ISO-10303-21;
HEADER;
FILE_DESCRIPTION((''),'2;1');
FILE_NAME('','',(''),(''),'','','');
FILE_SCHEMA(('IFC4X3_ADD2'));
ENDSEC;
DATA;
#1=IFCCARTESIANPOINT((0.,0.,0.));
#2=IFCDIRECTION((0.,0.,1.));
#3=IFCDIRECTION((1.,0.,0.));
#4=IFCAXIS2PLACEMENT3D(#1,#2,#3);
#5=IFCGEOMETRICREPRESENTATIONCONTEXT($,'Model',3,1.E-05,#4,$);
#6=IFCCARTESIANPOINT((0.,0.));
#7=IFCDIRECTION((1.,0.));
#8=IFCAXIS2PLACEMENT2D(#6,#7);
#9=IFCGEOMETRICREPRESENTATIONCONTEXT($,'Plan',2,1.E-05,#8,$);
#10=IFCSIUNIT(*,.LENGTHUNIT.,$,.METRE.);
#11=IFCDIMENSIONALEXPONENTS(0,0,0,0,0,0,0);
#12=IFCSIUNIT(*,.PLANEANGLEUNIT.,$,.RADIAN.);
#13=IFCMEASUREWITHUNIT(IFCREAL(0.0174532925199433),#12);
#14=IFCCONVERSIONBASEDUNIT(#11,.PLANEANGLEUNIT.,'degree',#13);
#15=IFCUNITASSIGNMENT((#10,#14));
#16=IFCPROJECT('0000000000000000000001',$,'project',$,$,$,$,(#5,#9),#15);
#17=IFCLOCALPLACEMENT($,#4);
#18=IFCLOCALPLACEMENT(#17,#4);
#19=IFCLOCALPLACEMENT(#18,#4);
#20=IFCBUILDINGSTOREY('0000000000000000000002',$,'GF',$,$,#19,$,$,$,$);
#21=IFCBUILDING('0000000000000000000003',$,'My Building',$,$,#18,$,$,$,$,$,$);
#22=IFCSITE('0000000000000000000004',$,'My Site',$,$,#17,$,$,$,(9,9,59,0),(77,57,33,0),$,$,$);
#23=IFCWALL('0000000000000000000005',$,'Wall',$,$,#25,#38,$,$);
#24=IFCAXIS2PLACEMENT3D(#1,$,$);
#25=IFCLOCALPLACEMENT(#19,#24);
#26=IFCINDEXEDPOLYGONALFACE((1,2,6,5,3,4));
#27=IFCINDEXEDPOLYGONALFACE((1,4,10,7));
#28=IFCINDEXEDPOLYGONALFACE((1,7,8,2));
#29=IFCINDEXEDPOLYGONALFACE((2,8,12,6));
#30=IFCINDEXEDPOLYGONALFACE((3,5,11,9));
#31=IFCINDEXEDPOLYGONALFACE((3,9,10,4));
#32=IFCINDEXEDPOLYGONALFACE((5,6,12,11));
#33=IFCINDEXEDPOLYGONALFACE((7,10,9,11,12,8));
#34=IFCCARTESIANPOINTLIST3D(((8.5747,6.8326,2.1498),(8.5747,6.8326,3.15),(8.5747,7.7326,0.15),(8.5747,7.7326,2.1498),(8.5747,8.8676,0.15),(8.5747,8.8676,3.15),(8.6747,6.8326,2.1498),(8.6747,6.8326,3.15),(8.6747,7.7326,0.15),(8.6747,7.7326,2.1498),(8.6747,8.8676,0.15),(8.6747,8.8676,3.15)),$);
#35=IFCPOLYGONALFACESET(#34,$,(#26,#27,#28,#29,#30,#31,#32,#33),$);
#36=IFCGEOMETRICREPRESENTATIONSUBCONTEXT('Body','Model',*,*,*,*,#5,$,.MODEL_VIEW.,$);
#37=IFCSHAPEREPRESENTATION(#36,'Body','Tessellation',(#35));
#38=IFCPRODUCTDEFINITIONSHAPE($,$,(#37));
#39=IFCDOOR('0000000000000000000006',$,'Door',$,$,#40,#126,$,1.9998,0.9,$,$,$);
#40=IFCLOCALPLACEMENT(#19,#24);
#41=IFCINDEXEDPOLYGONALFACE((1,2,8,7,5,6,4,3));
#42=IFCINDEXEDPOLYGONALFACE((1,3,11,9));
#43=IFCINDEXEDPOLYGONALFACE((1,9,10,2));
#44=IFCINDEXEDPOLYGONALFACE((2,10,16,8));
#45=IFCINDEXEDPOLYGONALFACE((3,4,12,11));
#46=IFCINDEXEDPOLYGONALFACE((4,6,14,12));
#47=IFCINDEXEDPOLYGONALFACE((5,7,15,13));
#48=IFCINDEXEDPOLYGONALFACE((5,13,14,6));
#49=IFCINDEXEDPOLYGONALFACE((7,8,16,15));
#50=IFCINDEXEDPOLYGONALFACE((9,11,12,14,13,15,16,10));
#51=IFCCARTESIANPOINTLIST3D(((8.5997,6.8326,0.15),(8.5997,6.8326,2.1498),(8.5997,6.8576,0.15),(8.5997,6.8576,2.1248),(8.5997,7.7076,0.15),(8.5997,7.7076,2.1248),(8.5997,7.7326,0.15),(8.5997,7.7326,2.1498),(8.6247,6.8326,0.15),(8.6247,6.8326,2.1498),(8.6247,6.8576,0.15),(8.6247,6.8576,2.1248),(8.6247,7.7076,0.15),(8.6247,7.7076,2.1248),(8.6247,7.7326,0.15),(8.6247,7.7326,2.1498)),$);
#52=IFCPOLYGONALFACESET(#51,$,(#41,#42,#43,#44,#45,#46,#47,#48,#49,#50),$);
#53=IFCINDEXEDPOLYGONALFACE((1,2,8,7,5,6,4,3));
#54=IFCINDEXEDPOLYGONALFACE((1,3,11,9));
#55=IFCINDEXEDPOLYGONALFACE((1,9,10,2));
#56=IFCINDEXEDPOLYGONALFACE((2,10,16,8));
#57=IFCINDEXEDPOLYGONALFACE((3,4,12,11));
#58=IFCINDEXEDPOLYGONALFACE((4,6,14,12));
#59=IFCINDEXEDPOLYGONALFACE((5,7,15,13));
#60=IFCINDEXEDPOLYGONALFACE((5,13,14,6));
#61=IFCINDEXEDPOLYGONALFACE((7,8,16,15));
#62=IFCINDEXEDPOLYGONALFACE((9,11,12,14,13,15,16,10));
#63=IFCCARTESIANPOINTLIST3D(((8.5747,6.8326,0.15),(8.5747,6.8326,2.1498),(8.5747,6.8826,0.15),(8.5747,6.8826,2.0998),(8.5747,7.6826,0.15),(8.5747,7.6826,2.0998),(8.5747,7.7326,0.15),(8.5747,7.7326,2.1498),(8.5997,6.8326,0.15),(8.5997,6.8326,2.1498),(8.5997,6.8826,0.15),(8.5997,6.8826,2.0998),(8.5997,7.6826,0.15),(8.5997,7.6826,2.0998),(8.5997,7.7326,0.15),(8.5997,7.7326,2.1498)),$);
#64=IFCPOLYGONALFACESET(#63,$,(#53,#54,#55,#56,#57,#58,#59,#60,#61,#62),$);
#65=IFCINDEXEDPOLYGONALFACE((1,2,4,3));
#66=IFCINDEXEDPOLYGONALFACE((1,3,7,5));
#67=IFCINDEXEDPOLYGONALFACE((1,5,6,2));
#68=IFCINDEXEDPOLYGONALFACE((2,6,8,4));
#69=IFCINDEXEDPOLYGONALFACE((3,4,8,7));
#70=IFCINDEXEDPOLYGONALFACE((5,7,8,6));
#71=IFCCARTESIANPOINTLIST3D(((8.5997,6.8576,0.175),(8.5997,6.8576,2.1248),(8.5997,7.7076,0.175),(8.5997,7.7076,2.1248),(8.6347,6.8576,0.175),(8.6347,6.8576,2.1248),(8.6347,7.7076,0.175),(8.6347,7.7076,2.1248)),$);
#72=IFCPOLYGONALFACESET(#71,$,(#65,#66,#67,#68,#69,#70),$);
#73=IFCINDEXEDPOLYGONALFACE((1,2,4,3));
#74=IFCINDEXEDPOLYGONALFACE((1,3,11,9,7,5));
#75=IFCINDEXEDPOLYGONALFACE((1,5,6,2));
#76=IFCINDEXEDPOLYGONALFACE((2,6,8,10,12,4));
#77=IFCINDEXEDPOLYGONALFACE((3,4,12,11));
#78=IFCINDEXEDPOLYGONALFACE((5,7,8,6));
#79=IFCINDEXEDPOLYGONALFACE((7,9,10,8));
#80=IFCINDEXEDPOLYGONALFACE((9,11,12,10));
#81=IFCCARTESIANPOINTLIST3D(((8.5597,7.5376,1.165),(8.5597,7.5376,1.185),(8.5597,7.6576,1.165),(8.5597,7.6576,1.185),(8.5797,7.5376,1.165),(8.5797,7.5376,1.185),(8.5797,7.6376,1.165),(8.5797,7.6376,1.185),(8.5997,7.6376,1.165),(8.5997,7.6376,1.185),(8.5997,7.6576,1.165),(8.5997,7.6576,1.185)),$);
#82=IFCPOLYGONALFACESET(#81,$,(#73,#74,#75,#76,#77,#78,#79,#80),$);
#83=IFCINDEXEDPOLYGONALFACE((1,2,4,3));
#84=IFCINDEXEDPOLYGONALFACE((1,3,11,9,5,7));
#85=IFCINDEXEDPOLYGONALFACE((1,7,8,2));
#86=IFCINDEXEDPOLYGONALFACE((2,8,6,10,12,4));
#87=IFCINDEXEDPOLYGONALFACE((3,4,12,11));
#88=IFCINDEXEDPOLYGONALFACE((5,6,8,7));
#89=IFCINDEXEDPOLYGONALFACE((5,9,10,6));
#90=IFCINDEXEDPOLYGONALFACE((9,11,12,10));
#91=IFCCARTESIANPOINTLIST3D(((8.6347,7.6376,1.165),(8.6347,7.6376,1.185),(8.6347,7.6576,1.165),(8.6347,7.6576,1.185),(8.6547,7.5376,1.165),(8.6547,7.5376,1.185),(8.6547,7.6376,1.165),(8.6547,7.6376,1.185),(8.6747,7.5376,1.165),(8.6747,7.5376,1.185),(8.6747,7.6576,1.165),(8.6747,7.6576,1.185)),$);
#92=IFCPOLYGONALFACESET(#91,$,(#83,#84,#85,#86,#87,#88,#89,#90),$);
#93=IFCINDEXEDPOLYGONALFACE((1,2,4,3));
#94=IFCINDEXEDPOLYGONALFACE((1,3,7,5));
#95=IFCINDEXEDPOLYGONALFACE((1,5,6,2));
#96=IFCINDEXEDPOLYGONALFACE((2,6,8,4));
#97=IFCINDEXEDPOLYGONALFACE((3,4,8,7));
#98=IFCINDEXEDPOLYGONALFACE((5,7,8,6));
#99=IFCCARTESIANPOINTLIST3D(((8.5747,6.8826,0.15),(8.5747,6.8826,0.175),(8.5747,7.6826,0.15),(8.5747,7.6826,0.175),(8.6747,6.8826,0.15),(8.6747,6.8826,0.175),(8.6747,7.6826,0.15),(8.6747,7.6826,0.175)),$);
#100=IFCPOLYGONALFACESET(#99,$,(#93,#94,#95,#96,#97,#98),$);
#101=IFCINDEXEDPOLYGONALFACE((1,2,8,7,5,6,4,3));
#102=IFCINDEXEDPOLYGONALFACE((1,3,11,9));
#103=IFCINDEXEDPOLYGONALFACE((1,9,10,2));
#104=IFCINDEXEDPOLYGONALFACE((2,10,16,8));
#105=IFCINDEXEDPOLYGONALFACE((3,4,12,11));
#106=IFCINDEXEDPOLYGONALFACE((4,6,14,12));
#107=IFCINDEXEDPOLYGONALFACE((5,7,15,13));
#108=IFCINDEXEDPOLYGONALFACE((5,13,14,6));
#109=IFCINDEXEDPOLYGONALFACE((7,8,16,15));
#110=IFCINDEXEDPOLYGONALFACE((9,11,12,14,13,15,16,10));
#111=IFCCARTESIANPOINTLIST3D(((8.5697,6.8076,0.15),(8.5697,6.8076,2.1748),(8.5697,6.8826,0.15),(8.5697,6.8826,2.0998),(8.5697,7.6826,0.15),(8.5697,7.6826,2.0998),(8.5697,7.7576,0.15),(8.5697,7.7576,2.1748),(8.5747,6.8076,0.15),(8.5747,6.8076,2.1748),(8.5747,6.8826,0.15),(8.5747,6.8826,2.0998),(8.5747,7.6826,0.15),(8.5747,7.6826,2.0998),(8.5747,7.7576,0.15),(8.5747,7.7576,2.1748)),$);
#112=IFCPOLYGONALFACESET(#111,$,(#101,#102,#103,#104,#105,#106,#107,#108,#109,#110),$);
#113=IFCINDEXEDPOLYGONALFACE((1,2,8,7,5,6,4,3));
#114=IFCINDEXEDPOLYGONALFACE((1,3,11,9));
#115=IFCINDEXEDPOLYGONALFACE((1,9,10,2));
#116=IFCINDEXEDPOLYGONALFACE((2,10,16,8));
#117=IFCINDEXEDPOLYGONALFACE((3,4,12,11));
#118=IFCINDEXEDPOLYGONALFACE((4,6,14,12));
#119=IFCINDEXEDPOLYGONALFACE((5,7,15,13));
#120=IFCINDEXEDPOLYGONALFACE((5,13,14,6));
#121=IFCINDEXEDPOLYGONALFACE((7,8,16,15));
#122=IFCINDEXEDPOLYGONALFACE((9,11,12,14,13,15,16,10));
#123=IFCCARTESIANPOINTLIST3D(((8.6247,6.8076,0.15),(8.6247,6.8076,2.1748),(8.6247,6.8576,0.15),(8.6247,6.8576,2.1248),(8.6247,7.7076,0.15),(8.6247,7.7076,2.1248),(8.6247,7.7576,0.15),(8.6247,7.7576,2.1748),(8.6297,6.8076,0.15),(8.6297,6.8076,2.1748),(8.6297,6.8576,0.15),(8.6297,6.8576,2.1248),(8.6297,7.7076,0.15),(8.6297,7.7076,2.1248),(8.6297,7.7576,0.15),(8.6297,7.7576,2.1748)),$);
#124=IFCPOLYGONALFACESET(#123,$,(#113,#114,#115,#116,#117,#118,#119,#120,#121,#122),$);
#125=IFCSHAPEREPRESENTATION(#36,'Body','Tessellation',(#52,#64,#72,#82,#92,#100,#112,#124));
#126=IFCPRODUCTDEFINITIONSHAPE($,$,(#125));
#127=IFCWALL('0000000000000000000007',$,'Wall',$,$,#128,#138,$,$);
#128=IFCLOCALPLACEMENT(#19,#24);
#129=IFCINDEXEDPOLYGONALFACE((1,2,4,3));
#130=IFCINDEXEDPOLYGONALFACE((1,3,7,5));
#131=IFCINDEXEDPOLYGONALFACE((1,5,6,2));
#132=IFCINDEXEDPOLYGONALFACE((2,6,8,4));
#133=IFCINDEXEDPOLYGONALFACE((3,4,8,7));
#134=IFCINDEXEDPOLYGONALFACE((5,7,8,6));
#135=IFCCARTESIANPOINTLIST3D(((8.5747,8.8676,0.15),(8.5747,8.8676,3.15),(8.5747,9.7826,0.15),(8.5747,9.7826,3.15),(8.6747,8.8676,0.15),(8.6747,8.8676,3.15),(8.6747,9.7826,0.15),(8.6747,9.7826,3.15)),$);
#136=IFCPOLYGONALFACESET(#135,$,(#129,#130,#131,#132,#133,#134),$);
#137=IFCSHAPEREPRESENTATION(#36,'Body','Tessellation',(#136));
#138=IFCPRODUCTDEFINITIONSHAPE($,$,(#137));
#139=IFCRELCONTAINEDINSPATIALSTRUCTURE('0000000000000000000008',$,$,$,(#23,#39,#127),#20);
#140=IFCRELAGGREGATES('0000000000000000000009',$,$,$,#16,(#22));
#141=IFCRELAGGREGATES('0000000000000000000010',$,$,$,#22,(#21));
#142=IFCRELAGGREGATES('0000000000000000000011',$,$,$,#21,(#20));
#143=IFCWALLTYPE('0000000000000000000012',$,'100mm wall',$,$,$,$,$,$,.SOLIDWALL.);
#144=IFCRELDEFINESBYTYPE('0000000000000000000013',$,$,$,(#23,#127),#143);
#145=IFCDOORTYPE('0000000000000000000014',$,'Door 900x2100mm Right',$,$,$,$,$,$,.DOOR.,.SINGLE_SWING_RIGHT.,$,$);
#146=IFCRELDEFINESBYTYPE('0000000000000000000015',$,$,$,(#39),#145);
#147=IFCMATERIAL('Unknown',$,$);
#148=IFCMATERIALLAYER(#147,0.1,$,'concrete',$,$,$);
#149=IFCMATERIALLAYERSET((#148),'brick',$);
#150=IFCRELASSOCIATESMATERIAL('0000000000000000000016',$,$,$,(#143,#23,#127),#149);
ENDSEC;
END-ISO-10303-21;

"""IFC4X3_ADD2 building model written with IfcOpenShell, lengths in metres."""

from ifc_helpers import new_model, entity, si_unit, converted_unit, frame, origin_with_axes, origin_2d_with_axis, place, context, subcontext, project, spatial, line, indexed_curve, outline, extrude, shape, source, transform, mapped, material, layer, layer_set, layer_usage, type_object, type_shapes, element, fill, save


model = new_model("IFC4X3_ADD2")

# Units and contexts
model_context = context("Model", 3, precision=1e-05, world=origin_with_axes())
plan_context = context("Plan", 2, precision=1e-05, world=origin_2d_with_axis())
body_context_1 = subcontext(model_context, "Body", "Model", "MODEL_VIEW")
body_context_2 = subcontext(plan_context, "Body", "Plan", "PLAN_VIEW")
ifc_project = project(units=[si_unit("LENGTHUNIT", "METRE"), converted_unit("PLANEANGLEUNIT", "degree", entity("IfcReal", 0.0174532925199433), si_unit("PLANEANGLEUNIT", "RADIAN"), dimensions=[0, 0, 0, 0, 0, 0, 0])], contexts=[model_context, plan_context])

# Site, building, storey
site_placement = place(None, origin_with_axes())
site = spatial("IfcSite", under=ifc_project, at=site_placement, Name="My Site", RefLatitude=(9, 9, 59, 0), RefLongitude=(77, 57, 33, 0))
building_placement = place(site_placement, origin_with_axes())
building = spatial("IfcBuilding", under=site, at=building_placement, Name="My Building")
storey_placement = place(building_placement, origin_with_axes())
storey = spatial("IfcBuildingStorey", under=building, at=storey_placement, Name="GF")

# Shared definitions
ifc_material = material(Name="Unknown")

# Shared definitions
ifc_layer_1 = layer(ifc_material, 0.1, Name="concrete")
ifc_layer_set_1 = layer_set([ifc_layer_1], Name="brick")
wall_type_1 = type_object("IfcWallType", Name="100mm wall", PredefinedType="SOLIDWALL", material=ifc_layer_set_1)

# Wall, opening, door
ifc_layer_usage_1 = layer_usage(ifc_layer_set_1, "AXIS2", "POSITIVE", 0.0)
wall_1_placement = place(storey_placement, frame((8.6747, 6.8326, 0.15), z_axis=(0.0, 0.0, 1.0), x_axis=(0.0, 1.0, 0.0)))
wall_1 = element("IfcWall", 1, at=wall_1_placement, inside=storey, type_object=wall_type_1, material=ifc_layer_usage_1, Name="Wall", context=body_context_1, shape_type="SweptSolid", body=[
    extrude(outline(indexed_curve([(0.0, 0.0), (0.0, 0.1), (2.035, 0.1), (2.035, 0.0)], segments=[line(1, 2, 3, 4, 1)])), origin_with_axes(), (0.0, 0.0, 1.0), 3.0),
])
shared_shape_1 = source(origin_with_axes(), body_context_1, "Body", "SweptSolid", [
    extrude(outline(indexed_curve([(0.0, 0.0), (0.9, 0.0), (0.9, 1.9998), (0.0, 1.9998)], segments=[line(1, 2, 3, 4, 1)])), frame((0.0, -0.6, 0.0), z_axis=(0.0, -1.0, 0.0), x_axis=(1.0, 0.0, 0.0)), (0.0, 0.0, -1.0), 1.2),
])
opening_1_placement = place(wall_1_placement, frame((0.9, 0.1, 0.0), z_axis=(0.0, 0.0, 1.0), x_axis=(-1.0, 0.0, 0.0)))
opening_1 = element("IfcOpeningElement", 2, at=opening_1_placement, cuts=wall_1, PredefinedType="OPENING", context=body_context_1, shape_type="MappedRepresentation", body=[
    mapped(shared_shape_1, transform((0.0, 0.0, 0.0), x_axis=(1.0, 0.0, 0.0), y_axis=(0.0, 1.0, 0.0), z_axis=(0.0, 0.0, 1.0), scale=1.0)),
])
door_type = type_object("IfcDoorType", Name="Door 900x2100mm Right", OperationType="SINGLE_SWING_RIGHT", PredefinedType="DOOR")
shared_shape_2 = source(origin_with_axes(), body_context_1, "Body", "SweptSolid", [
    extrude(outline(indexed_curve([(0.0, 0.0), (0.0, 1.9998), (0.9, 1.9998), (0.9, 0.0), (0.875, 0.0), (0.875, 1.9748), (0.025, 1.9748), (0.025, 0.0)], segments=[line(1, 2, 3, 4, 5, 6, 7, 8, 1)])), frame((0.0, 0.025, 0.0), z_axis=(0.0, -1.0, 0.0), x_axis=(1.0, 0.0, 0.0)), (0.0, 0.0, -1.0), 0.025),
    extrude(outline(indexed_curve([(0.0, 0.0), (0.0, 1.9998), (0.9, 1.9998), (0.9, 0.0), (0.85, 0.0), (0.85, 1.9498), (0.05, 1.9498), (0.05, 0.0)], segments=[line(1, 2, 3, 4, 5, 6, 7, 8, 1)])), frame((0.0, 0.0, 0.0), z_axis=(0.0, -1.0, 0.0), x_axis=(1.0, 0.0, 0.0)), (0.0, 0.0, -1.0), 0.025),
    extrude(outline(indexed_curve([(0.0, 0.0), (0.85, 0.0), (0.85, 0.035), (0.0, 0.035)], segments=[line(1, 2, 3, 4, 1)])), frame((0.025, 0.025, 0.025), z_axis=(0.0, 0.0, 1.0), x_axis=(1.0, 0.0, 0.0)), (0.0, 0.0, 1.0), 1.9498),
    extrude(outline(indexed_curve([(0.0, 0.0), (0.0, -0.04), (0.12, -0.04), (0.12, -0.02), (0.02, -0.02), (0.02, 0.0)], segments=[line(1, 2, 3, 4, 5, 6, 1)])), frame((0.075, 0.025, 1.015), z_axis=(0.0, 0.0, 1.0), x_axis=(1.0, 0.0, 0.0)), (0.0, 0.0, 1.0), 0.02),
    extrude(outline(indexed_curve([(0.0, 0.0), (0.0, 0.04), (0.12, 0.04), (0.12, 0.02), (0.02, 0.02), (0.02, 0.0)], segments=[line(1, 2, 3, 4, 5, 6, 1)])), frame((0.075, 0.06, 1.015), z_axis=(0.0, 0.0, 1.0), x_axis=(1.0, 0.0, 0.0)), (0.0, 0.0, 1.0), 0.02),
    extrude(outline(indexed_curve([(0.0, 0.0), (0.8, 0.0), (0.8, 0.1), (0.0, 0.1)], segments=[line(1, 2, 3, 4, 1)])), frame((0.05, 0.0, 0.0), z_axis=(0.0, 0.0, 1.0), x_axis=(1.0, 0.0, 0.0)), (0.0, 0.0, 1.0), 0.025),
    extrude(outline(indexed_curve([(0.0, 0.0), (0.0, 2.0248), (0.95, 2.0248), (0.95, 0.0), (0.875, 0.0), (0.875, 1.9498), (0.075, 1.9498), (0.075, 0.0)], segments=[line(1, 2, 3, 4, 5, 6, 7, 8, 1)])), frame((-0.025, -0.005, 0.0), z_axis=(0.0, -1.0, 0.0), x_axis=(1.0, 0.0, 0.0)), (0.0, 0.0, -1.0), 0.005),
    extrude(outline(indexed_curve([(0.0, 0.0), (0.0, 2.0248), (0.95, 2.0248), (0.95, 0.0), (0.9, 0.0), (0.9, 1.9748), (0.05, 1.9748), (0.05, 0.0)], segments=[line(1, 2, 3, 4, 5, 6, 7, 8, 1)])), frame((-0.025, 0.05, 0.0), z_axis=(0.0, -1.0, 0.0), x_axis=(1.0, 0.0, 0.0)), (0.0, 0.0, -1.0), 0.005),
])
shared_shape_3 = source(origin_with_axes(), body_context_2, "Body", "Curve2D", [
    entity("IfcIndexedPolyCurve", entity("IfcCartesianPointList2D", [[0.0, 0.0], [0.0, 0.05], [0.025, 0.05], [0.025, 0.025], [0.05, 0.025], [0.05, 0.0]]), [entity("IfcLineIndex", [1, 2, 3, 4, 5, 6, 1])]),
    entity("IfcIndexedPolyCurve", entity("IfcCartesianPointList2D", [[0.9, 0.0], [0.9, 0.05], [0.875, 0.05], [0.875, 0.025], [0.85, 0.025], [0.85, 0.0]]), [entity("IfcLineIndex", [1, 2, 3, 4, 5, 6, 1])]),
    entity("IfcTrimmedCurve", entity("IfcEllipse", entity("IfcAxis2Placement2D", entity("IfcCartesianPoint", [0.84, 0.05]), entity("IfcDirection", [1.0, 0.0])), 0.815, 0.85), [entity("IfcCartesianPoint", [0.84, 0.9])], [entity("IfcCartesianPoint", [0.025, 0.05])], True, "CARTESIAN"),
    entity("IfcIndexedPolyCurve", entity("IfcCartesianPointList2D", [[0.875, 0.05], [0.84, 0.05], [0.84, 0.9], [0.875, 0.9]]), [entity("IfcLineIndex", [1, 2, 3, 4, 1])]),
])
type_shapes(door_type, [shared_shape_2, shared_shape_3])
door_1_placement = place(opening_1_placement, origin_with_axes())
door_1 = element("IfcDoor", 3, at=door_1_placement, inside=storey, type_object=door_type, Name="Door", OverallHeight=1.9998, OverallWidth=0.9, shapes=[
    shape(body_context_1, "Body", "MappedRepresentation", [mapped(shared_shape_2, transform((0.0, 0.0, 0.0), x_axis=(1.0, 0.0, 0.0), y_axis=(0.0, 1.0, 0.0), z_axis=(0.0, 0.0, 1.0), scale=1.0))]),
    shape(body_context_2, "Body", "MappedRepresentation", [mapped(shared_shape_3, transform((0.0, 0.0, 0.0), x_axis=(1.0, 0.0, 0.0), y_axis=(0.0, 1.0, 0.0), z_axis=(0.0, 0.0, 1.0), scale=1.0))]),
])
fill(opening_1, door_1)

# Wall
ifc_layer_usage_2 = layer_usage(ifc_layer_set_1, "AXIS2", "POSITIVE", 0.0)
wall_2_placement = place(storey_placement, frame((8.6747, 8.8676, 0.15), z_axis=(0.0, 0.0, 1.0), x_axis=(0.0, 1.0, 0.0)))
element("IfcWall", 4, at=wall_2_placement, inside=storey, type_object=wall_type_1, material=ifc_layer_usage_2, Name="Wall", context=body_context_1, shape_type="SweptSolid", body=[
    extrude(outline(indexed_curve([(0.0, 0.0), (0.0, 0.1), (0.915, 0.1), (0.915, 0.0)], segments=[line(1, 2, 3, 4, 1)])), origin_with_axes(), (0.0, 0.0, 1.0), 3.0),
])

save(model, "model.ifc")
